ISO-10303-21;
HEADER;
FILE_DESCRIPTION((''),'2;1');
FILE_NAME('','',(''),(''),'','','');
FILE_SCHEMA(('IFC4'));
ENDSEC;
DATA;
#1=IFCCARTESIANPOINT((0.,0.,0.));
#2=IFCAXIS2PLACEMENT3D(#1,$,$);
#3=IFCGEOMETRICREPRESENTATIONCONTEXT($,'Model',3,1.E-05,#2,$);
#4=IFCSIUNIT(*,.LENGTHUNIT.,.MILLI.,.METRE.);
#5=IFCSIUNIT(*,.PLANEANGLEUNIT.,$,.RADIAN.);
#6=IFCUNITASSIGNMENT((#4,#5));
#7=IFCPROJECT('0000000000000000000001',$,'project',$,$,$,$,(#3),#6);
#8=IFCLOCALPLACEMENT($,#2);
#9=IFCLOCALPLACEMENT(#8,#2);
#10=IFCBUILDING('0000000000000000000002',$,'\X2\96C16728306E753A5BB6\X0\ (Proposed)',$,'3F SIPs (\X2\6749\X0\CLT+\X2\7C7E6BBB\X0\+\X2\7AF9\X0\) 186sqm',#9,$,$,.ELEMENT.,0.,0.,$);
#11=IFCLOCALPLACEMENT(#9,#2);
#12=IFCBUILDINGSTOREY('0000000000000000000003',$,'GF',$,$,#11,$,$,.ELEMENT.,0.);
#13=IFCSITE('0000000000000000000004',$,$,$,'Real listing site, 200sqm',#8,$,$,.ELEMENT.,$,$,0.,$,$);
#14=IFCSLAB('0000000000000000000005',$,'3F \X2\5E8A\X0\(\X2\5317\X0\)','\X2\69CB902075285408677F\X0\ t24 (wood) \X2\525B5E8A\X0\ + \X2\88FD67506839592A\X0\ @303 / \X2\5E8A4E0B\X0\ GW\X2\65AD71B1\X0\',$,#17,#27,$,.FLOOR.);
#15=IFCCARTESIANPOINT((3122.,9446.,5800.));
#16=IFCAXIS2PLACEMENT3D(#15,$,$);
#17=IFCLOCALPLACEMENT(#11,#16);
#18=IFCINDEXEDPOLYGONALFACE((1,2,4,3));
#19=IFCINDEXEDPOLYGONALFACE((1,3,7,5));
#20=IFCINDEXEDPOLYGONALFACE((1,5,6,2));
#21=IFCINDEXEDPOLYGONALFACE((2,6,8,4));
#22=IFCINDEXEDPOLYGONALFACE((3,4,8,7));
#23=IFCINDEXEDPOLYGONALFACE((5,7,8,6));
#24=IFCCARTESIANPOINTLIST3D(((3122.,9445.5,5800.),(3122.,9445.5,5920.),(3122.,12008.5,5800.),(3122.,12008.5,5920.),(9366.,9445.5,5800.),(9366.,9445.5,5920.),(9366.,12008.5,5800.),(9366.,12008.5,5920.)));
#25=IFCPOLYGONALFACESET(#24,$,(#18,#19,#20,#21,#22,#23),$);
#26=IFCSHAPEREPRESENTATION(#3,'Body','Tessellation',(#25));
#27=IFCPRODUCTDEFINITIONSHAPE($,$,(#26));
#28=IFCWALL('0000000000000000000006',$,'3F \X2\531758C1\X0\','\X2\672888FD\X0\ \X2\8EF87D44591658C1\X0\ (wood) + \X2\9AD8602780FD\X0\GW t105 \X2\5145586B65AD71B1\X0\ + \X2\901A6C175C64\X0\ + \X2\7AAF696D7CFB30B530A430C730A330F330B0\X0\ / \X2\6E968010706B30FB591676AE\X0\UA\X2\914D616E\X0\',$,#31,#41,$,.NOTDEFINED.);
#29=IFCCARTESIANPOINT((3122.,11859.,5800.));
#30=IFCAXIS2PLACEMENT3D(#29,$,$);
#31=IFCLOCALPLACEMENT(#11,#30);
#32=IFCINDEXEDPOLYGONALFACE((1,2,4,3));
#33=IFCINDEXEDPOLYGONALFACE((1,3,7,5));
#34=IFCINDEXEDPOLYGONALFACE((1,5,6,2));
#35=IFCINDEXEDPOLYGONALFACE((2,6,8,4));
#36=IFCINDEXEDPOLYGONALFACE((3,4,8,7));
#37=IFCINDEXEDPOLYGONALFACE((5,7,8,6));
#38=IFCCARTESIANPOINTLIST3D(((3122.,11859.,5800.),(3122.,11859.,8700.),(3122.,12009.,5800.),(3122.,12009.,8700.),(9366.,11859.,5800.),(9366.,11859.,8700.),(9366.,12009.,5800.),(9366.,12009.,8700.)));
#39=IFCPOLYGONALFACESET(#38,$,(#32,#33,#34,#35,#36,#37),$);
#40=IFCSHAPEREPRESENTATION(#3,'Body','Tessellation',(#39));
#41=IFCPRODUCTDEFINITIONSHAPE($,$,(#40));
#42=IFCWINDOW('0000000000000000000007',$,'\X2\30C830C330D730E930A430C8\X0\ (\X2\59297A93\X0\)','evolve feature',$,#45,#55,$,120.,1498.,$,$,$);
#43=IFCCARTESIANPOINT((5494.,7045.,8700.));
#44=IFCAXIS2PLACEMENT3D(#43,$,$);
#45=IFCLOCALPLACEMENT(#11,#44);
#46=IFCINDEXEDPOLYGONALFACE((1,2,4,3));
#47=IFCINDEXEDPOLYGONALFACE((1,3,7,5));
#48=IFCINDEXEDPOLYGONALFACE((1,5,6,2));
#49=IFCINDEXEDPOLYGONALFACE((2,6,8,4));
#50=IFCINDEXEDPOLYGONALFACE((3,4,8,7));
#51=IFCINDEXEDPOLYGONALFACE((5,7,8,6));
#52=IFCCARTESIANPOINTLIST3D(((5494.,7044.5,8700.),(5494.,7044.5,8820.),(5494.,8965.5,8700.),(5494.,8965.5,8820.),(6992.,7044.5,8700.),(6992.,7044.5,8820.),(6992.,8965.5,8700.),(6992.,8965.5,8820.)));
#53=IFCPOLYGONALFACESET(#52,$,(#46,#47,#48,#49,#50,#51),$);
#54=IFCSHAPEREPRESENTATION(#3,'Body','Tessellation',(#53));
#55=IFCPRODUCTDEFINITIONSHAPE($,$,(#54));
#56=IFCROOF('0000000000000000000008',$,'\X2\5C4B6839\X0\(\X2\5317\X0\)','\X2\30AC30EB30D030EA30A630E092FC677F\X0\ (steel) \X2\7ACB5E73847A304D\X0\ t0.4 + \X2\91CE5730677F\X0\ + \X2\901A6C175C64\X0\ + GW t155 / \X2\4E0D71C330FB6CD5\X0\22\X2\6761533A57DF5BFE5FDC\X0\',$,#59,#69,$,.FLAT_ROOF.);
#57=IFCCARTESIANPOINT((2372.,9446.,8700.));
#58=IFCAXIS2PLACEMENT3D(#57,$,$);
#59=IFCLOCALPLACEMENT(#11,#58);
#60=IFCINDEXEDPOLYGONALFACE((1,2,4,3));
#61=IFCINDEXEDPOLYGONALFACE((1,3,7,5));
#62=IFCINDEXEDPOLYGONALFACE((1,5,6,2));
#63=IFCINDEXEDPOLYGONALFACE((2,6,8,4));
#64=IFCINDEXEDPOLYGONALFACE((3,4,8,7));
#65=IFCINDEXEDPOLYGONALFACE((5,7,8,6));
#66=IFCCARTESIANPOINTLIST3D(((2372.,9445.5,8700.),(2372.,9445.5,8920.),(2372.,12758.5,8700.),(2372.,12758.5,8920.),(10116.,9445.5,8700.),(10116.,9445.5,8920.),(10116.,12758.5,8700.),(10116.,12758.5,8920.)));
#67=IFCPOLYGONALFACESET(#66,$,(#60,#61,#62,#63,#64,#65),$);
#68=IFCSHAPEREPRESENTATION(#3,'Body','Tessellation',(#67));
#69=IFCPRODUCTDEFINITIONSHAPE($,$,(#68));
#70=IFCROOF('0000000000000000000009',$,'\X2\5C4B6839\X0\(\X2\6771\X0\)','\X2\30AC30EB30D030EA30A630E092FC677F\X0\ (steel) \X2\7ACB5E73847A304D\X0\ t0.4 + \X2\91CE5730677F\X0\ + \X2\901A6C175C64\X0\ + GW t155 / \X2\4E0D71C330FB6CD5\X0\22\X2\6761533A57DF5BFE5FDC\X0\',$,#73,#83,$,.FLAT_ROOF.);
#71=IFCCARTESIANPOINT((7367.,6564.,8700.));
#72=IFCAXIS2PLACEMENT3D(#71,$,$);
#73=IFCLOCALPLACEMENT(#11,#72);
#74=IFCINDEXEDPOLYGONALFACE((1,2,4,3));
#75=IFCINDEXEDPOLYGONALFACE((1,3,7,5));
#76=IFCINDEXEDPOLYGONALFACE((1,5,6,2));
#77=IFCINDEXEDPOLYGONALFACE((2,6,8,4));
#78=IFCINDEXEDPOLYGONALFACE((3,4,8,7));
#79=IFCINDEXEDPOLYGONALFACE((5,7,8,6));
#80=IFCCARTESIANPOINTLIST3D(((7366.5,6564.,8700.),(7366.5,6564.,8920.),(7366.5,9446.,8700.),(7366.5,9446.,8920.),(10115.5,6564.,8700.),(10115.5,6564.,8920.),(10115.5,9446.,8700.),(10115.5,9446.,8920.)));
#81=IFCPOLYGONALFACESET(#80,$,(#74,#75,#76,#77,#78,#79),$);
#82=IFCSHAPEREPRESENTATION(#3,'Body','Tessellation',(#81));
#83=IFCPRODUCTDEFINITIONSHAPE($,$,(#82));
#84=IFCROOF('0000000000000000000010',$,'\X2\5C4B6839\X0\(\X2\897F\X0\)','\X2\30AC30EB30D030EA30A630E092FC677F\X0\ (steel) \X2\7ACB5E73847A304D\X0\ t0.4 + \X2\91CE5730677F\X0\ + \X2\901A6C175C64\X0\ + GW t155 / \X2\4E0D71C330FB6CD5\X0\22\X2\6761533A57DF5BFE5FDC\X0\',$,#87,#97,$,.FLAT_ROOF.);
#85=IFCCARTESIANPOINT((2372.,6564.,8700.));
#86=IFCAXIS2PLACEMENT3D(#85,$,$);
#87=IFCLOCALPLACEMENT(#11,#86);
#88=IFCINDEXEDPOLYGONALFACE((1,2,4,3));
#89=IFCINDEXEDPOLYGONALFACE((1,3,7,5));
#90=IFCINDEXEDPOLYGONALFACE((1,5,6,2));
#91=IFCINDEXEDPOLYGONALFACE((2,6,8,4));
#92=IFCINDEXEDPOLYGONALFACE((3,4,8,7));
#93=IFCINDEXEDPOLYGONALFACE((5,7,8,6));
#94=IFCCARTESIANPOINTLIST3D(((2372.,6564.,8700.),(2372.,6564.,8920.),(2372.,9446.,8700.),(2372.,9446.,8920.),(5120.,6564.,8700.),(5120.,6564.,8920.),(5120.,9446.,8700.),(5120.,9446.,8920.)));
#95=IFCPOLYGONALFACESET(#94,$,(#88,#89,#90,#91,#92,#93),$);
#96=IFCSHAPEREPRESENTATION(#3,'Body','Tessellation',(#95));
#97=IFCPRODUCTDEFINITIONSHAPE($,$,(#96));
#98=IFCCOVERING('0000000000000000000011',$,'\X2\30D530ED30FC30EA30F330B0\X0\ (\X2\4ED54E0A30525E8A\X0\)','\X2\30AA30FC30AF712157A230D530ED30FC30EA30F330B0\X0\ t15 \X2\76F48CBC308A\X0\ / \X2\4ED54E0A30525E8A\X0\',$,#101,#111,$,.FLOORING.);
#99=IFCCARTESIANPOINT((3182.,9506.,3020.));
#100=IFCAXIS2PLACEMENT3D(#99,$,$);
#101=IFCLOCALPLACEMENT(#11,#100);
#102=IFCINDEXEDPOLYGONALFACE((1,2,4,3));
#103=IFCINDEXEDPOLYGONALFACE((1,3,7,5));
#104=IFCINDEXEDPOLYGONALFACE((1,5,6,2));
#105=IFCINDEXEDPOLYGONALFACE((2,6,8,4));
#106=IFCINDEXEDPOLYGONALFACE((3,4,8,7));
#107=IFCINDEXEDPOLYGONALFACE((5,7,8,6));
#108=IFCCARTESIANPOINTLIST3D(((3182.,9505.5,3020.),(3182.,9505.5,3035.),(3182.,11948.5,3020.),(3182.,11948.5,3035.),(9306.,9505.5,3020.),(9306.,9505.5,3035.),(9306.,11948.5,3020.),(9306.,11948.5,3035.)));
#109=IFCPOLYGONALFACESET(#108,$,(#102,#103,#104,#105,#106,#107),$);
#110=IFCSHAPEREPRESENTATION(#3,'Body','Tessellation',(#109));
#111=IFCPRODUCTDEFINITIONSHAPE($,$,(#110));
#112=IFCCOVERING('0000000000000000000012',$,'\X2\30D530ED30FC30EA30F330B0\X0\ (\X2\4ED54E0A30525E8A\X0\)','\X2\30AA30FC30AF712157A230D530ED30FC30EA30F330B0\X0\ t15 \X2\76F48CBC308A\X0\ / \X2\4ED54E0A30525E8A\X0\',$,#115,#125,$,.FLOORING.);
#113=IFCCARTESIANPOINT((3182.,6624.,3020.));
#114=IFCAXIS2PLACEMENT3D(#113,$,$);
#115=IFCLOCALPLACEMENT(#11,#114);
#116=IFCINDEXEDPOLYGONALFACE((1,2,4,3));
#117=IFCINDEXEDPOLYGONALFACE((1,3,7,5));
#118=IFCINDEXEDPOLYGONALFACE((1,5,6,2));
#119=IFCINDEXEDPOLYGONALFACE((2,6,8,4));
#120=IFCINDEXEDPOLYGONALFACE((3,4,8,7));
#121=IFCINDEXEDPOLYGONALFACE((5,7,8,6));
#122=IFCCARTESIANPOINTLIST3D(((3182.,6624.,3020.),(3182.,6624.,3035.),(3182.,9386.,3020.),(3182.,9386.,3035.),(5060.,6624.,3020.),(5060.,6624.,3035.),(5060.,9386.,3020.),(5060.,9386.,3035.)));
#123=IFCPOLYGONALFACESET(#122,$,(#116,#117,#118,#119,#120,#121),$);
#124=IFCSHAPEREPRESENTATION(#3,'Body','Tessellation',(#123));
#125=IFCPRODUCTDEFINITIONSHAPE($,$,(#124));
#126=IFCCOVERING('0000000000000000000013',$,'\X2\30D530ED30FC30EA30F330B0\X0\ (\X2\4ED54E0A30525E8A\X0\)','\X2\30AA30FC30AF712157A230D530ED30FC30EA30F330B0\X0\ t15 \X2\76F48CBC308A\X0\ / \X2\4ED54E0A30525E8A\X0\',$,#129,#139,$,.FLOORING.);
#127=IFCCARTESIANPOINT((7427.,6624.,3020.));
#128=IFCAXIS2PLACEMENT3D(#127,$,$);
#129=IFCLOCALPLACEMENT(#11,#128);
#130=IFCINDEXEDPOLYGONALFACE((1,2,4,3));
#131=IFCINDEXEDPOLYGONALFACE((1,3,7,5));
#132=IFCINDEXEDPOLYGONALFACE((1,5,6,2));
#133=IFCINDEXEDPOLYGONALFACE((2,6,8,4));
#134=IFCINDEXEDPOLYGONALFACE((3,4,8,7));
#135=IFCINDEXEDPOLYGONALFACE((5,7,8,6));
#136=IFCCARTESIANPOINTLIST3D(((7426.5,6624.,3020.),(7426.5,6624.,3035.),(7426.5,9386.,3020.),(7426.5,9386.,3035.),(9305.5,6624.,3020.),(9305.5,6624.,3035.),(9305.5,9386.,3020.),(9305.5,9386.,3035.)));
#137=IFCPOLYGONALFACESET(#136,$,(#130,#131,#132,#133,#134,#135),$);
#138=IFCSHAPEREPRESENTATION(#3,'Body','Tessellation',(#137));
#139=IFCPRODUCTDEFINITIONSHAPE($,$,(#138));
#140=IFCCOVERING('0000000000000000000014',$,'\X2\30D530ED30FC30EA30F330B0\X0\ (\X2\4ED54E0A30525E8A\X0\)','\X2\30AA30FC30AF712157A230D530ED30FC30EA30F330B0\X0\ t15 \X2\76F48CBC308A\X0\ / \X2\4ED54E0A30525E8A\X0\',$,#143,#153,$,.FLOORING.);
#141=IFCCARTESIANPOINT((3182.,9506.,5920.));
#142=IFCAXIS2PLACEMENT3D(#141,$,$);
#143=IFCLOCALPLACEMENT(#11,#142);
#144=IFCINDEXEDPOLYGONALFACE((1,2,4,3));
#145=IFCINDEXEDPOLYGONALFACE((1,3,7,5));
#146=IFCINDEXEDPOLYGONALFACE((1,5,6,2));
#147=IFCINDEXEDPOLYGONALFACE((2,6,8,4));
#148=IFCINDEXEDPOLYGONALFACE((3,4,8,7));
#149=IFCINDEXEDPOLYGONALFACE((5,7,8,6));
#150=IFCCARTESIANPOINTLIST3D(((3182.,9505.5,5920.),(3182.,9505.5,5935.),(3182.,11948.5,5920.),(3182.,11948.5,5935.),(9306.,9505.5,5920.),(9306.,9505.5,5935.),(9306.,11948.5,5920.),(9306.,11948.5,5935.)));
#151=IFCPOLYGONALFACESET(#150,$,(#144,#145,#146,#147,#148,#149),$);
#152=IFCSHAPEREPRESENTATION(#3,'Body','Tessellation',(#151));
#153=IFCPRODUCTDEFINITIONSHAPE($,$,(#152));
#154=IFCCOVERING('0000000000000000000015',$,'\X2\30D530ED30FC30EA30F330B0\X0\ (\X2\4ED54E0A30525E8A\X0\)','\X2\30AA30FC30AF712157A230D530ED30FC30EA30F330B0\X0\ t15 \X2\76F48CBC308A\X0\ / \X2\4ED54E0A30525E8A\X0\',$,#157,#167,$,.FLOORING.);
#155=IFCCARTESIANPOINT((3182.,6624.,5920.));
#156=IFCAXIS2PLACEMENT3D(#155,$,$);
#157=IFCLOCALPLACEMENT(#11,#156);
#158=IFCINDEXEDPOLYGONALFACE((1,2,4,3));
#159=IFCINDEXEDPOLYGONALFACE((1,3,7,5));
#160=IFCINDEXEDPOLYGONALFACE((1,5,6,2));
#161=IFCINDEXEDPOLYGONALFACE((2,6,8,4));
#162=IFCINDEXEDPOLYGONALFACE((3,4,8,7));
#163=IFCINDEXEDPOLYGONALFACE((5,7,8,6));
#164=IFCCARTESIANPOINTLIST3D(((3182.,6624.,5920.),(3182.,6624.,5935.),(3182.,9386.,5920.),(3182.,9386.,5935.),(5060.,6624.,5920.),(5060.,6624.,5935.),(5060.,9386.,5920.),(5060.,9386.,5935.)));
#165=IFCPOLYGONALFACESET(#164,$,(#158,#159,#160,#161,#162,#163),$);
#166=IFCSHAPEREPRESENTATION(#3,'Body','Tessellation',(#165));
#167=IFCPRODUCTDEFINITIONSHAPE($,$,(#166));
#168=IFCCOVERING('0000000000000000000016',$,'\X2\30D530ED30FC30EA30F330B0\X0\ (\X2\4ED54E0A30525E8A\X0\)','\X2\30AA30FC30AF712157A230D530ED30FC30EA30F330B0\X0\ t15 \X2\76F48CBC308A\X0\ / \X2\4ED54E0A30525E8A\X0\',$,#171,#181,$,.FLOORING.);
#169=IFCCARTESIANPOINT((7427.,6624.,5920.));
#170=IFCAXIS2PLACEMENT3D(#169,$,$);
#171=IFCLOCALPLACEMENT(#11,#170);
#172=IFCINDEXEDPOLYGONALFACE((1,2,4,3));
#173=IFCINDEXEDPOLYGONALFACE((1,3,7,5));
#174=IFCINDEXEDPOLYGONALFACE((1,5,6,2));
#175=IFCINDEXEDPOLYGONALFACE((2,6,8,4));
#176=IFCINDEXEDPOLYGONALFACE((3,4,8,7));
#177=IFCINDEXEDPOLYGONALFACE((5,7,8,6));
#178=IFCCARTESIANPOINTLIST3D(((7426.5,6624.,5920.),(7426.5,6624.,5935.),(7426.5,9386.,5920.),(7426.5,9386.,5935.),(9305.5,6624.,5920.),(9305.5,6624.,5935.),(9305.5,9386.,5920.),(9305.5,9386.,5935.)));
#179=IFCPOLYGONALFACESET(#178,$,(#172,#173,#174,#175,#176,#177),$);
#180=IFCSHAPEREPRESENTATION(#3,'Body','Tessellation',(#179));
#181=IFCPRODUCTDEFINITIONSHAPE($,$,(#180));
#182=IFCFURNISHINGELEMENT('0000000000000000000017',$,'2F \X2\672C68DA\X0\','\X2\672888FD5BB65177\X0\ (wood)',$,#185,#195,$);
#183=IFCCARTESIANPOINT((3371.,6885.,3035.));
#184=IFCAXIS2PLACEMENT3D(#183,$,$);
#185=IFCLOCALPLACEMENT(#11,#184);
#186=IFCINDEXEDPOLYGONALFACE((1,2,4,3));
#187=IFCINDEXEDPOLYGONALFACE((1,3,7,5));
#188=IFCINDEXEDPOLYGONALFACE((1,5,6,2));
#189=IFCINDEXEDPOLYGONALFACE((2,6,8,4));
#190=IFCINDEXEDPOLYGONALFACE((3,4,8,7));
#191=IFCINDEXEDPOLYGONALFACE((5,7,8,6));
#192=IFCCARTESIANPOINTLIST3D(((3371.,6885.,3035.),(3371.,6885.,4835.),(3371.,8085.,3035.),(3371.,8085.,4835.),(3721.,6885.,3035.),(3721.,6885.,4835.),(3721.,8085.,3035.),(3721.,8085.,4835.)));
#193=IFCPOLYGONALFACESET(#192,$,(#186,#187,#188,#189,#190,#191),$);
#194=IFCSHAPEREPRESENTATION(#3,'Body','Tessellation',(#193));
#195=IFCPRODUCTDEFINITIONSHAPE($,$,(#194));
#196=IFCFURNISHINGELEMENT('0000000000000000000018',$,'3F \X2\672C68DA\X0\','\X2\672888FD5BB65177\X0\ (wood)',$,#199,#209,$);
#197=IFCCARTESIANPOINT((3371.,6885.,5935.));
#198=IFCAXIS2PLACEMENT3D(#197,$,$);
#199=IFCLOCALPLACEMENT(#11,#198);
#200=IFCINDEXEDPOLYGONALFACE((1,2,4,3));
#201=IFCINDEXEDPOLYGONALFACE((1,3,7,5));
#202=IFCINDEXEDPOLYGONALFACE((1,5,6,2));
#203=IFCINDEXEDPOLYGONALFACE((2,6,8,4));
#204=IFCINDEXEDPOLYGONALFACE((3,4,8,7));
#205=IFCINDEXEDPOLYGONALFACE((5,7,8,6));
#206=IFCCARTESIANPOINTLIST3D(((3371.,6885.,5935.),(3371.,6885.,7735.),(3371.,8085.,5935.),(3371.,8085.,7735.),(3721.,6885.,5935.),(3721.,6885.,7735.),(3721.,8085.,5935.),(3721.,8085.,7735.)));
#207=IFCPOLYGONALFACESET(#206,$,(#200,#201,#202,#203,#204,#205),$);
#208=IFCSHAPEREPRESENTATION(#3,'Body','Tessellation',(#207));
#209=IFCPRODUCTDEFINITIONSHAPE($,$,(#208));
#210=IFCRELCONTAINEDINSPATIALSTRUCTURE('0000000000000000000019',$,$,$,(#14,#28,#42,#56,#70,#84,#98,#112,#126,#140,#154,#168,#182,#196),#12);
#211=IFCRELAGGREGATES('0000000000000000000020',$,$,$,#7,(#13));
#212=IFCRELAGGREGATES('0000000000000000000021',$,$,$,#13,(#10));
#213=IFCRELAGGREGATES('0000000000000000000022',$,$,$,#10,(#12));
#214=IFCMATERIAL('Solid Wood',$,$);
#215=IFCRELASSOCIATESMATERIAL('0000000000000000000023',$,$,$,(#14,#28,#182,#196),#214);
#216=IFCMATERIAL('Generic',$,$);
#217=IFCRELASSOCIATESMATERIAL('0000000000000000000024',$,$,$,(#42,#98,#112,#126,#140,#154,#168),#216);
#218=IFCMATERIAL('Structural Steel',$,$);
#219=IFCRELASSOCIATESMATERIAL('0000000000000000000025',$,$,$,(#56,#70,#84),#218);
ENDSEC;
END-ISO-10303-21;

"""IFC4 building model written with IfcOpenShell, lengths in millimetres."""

from ifc_helpers import new_model, si_unit, frame, frame_2d, origin, place, context, project, spatial, rectangle, extrude, material, element, save


model = new_model("IFC4")

# Units and contexts
model_context = context("Model", 3, precision=1e-05, world=origin())
ifc_project = project(units=[si_unit("LENGTHUNIT", "METRE", prefix="MILLI"), si_unit("PLANEANGLEUNIT", "RADIAN")], contexts=[model_context])

# Site, building, storey
site_placement = place(None, origin())
site = spatial("IfcSite", under=ifc_project, at=site_placement, ObjectType="Real listing site, 200sqm", CompositionType="ELEMENT", RefElevation=0.0)
building_placement = place(site_placement, origin())
building = spatial("IfcBuilding", under=site, at=building_placement, Name="雁木の町家 (Proposed)", ObjectType="3F SIPs (杉CLT+籾殻+竹) 186sqm", CompositionType="ELEMENT", ElevationOfRefHeight=0.0, ElevationOfTerrain=0.0)
storey_placement = place(building_placement, origin())
storey = spatial("IfcBuildingStorey", under=building, at=storey_placement, Name="GF", CompositionType="ELEMENT", Elevation=0.0)

# Slab
ifc_material_1 = material(Name="Solid Wood")
slab_placement = place(storey_placement, frame((3122.0, 9446.0, 5800.0)))
element("IfcSlab", 1, at=slab_placement, inside=storey, material=ifc_material_1, Name="3F 床(北)", Description="構造用合板 t24 (wood) 剛床 + 製材根太 @303 / 床下 GW断熱", PredefinedType="FLOOR", context=model_context, shape_type="SweptSolid", body=[
    extrude(rectangle(XDim=6244.0, YDim=2563.0, at=frame_2d((3122.0, 1281.0))), frame((3122.0, 9446.0, 5800.0)), (0.0, 0.0, 1.0), 120.0),
])

# Wall
wall_1_placement = place(storey_placement, frame((3122.0, 11859.0, 5800.0)))
element("IfcWall", 2, at=wall_1_placement, inside=storey, material=ifc_material_1, Name="3F 北壁", Description="木製 軸組外壁 (wood) + 高性能GW t105 充填断熱 + 通気層 + 窯業系サイディング / 準耐火・外皮UA配慮", PredefinedType="NOTDEFINED", context=model_context, shape_type="SweptSolid", body=[
    extrude(rectangle(XDim=6244.0, YDim=150.0, at=frame_2d((3122.0, 75.0))), frame((3122.0, 11859.0, 5800.0)), (0.0, 0.0, 1.0), 2900.0),
])

# Window
ifc_material_2 = material(Name="Generic")
window_1_placement = place(storey_placement, frame((5494.0, 7045.0, 8700.0)))
element("IfcWindow", 3, at=window_1_placement, inside=storey, material=ifc_material_2, Name="トップライト (天窓)", Description="evolve feature", OverallHeight=120.0, OverallWidth=1498.0, context=model_context, shape_type="SweptSolid", body=[
    extrude(rectangle(XDim=1498.0, YDim=1921.0, at=frame_2d((749.0, 960.0))), frame((5494.0, 7045.0, 8700.0)), (0.0, 0.0, 1.0), 120.0),
])

# Roofs
ifc_material_3 = material(Name="Structural Steel")
roof_1_placement = place(storey_placement, frame((2372.0, 9446.0, 8700.0)))
element("IfcRoof", 4, at=roof_1_placement, inside=storey, material=ifc_material_3, Name="屋根(北)", Description="ガルバリウム鋼板 (steel) 立平葺き t0.4 + 野地板 + 通気層 + GW t155 / 不燃・法22条区域対応", PredefinedType="FLAT_ROOF", context=model_context, shape_type="SweptSolid", body=[
    extrude(rectangle(XDim=7744.0, YDim=3313.0, at=frame_2d((3872.0, 1656.0))), frame((2372.0, 9446.0, 8700.0)), (0.0, 0.0, 1.0), 220.0),
])
roof_2_placement = place(storey_placement, frame((7367.0, 6564.0, 8700.0)))
element("IfcRoof", 5, at=roof_2_placement, inside=storey, material=ifc_material_3, Name="屋根(東)", Description="ガルバリウム鋼板 (steel) 立平葺き t0.4 + 野地板 + 通気層 + GW t155 / 不燃・法22条区域対応", PredefinedType="FLAT_ROOF", context=model_context, shape_type="SweptSolid", body=[
    extrude(rectangle(XDim=2749.0, YDim=2882.0, at=frame_2d((1374.0, 1441.0))), frame((7367.0, 6564.0, 8700.0)), (0.0, 0.0, 1.0), 220.0),
])
roof_3_placement = place(storey_placement, frame((2372.0, 6564.0, 8700.0)))
element("IfcRoof", 6, at=roof_3_placement, inside=storey, material=ifc_material_3, Name="屋根(西)", Description="ガルバリウム鋼板 (steel) 立平葺き t0.4 + 野地板 + 通気層 + GW t155 / 不燃・法22条区域対応", PredefinedType="FLAT_ROOF", context=model_context, shape_type="SweptSolid", body=[
    extrude(rectangle(XDim=2748.0, YDim=2882.0, at=frame_2d((1374.0, 1441.0))), frame((2372.0, 6564.0, 8700.0)), (0.0, 0.0, 1.0), 220.0),
])

# Coverings
covering_1_placement = place(storey_placement, frame((3182.0, 9506.0, 3020.0)))
element("IfcCovering", 7, at=covering_1_placement, inside=storey, material=ifc_material_2, Name="フローリング (仕上げ床)", Description="オーク無垢フローリング t15 直貼り / 仕上げ床", PredefinedType="FLOORING", context=model_context, shape_type="SweptSolid", body=[
    extrude(rectangle(XDim=6124.0, YDim=2443.0, at=frame_2d((3062.0, 1221.0))), frame((3182.0, 9506.0, 3020.0)), (0.0, 0.0, 1.0), 15.0),
])
covering_2_placement = place(storey_placement, frame((3182.0, 6624.0, 3020.0)))
element("IfcCovering", 8, at=covering_2_placement, inside=storey, material=ifc_material_2, Name="フローリング (仕上げ床)", Description="オーク無垢フローリング t15 直貼り / 仕上げ床", PredefinedType="FLOORING", context=model_context, shape_type="SweptSolid", body=[
    extrude(rectangle(XDim=1878.0, YDim=2762.0, at=frame_2d((939.0, 1381.0))), frame((3182.0, 6624.0, 3020.0)), (0.0, 0.0, 1.0), 15.0),
])
covering_3_placement = place(storey_placement, frame((7427.0, 6624.0, 3020.0)))
element("IfcCovering", 9, at=covering_3_placement, inside=storey, material=ifc_material_2, Name="フローリング (仕上げ床)", Description="オーク無垢フローリング t15 直貼り / 仕上げ床", PredefinedType="FLOORING", context=model_context, shape_type="SweptSolid", body=[
    extrude(rectangle(XDim=1879.0, YDim=2762.0, at=frame_2d((939.0, 1381.0))), frame((7427.0, 6624.0, 3020.0)), (0.0, 0.0, 1.0), 15.0),
])
covering_4_placement = place(storey_placement, frame((3182.0, 9506.0, 5920.0)))
element("IfcCovering", 10, at=covering_4_placement, inside=storey, material=ifc_material_2, Name="フローリング (仕上げ床)", Description="オーク無垢フローリング t15 直貼り / 仕上げ床", PredefinedType="FLOORING", context=model_context, shape_type="SweptSolid", body=[
    extrude(rectangle(XDim=6124.0, YDim=2443.0, at=frame_2d((3062.0, 1221.0))), frame((3182.0, 9506.0, 5920.0)), (0.0, 0.0, 1.0), 15.0),
])
covering_5_placement = place(storey_placement, frame((3182.0, 6624.0, 5920.0)))
element("IfcCovering", 11, at=covering_5_placement, inside=storey, material=ifc_material_2, Name="フローリング (仕上げ床)", Description="オーク無垢フローリング t15 直貼り / 仕上げ床", PredefinedType="FLOORING", context=model_context, shape_type="SweptSolid", body=[
    extrude(rectangle(XDim=1878.0, YDim=2762.0, at=frame_2d((939.0, 1381.0))), frame((3182.0, 6624.0, 5920.0)), (0.0, 0.0, 1.0), 15.0),
])
covering_6_placement = place(storey_placement, frame((7427.0, 6624.0, 5920.0)))
element("IfcCovering", 12, at=covering_6_placement, inside=storey, material=ifc_material_2, Name="フローリング (仕上げ床)", Description="オーク無垢フローリング t15 直貼り / 仕上げ床", PredefinedType="FLOORING", context=model_context, shape_type="SweptSolid", body=[
    extrude(rectangle(XDim=1879.0, YDim=2762.0, at=frame_2d((939.0, 1381.0))), frame((7427.0, 6624.0, 5920.0)), (0.0, 0.0, 1.0), 15.0),
])

# Furnishing elements
furnishing_1_placement = place(storey_placement, frame((3371.0, 6885.0, 3035.0)))
element("IfcFurnishingElement", 13, at=furnishing_1_placement, inside=storey, material=ifc_material_1, Name="2F 本棚", Description="木製家具 (wood)", context=model_context, shape_type="SweptSolid", body=[
    extrude(rectangle(XDim=350.0, YDim=1200.0, at=frame_2d((175.0, 600.0))), frame((3371.0, 6885.0, 3035.0)), (0.0, 0.0, 1.0), 1800.0),
])
furnishing_2_placement = place(storey_placement, frame((3371.0, 6885.0, 5935.0)))
element("IfcFurnishingElement", 14, at=furnishing_2_placement, inside=storey, material=ifc_material_1, Name="3F 本棚", Description="木製家具 (wood)", context=model_context, shape_type="SweptSolid", body=[
    extrude(rectangle(XDim=350.0, YDim=1200.0, at=frame_2d((175.0, 600.0))), frame((3371.0, 6885.0, 5935.0)), (0.0, 0.0, 1.0), 1800.0),
])

save(model, "model.ifc")
